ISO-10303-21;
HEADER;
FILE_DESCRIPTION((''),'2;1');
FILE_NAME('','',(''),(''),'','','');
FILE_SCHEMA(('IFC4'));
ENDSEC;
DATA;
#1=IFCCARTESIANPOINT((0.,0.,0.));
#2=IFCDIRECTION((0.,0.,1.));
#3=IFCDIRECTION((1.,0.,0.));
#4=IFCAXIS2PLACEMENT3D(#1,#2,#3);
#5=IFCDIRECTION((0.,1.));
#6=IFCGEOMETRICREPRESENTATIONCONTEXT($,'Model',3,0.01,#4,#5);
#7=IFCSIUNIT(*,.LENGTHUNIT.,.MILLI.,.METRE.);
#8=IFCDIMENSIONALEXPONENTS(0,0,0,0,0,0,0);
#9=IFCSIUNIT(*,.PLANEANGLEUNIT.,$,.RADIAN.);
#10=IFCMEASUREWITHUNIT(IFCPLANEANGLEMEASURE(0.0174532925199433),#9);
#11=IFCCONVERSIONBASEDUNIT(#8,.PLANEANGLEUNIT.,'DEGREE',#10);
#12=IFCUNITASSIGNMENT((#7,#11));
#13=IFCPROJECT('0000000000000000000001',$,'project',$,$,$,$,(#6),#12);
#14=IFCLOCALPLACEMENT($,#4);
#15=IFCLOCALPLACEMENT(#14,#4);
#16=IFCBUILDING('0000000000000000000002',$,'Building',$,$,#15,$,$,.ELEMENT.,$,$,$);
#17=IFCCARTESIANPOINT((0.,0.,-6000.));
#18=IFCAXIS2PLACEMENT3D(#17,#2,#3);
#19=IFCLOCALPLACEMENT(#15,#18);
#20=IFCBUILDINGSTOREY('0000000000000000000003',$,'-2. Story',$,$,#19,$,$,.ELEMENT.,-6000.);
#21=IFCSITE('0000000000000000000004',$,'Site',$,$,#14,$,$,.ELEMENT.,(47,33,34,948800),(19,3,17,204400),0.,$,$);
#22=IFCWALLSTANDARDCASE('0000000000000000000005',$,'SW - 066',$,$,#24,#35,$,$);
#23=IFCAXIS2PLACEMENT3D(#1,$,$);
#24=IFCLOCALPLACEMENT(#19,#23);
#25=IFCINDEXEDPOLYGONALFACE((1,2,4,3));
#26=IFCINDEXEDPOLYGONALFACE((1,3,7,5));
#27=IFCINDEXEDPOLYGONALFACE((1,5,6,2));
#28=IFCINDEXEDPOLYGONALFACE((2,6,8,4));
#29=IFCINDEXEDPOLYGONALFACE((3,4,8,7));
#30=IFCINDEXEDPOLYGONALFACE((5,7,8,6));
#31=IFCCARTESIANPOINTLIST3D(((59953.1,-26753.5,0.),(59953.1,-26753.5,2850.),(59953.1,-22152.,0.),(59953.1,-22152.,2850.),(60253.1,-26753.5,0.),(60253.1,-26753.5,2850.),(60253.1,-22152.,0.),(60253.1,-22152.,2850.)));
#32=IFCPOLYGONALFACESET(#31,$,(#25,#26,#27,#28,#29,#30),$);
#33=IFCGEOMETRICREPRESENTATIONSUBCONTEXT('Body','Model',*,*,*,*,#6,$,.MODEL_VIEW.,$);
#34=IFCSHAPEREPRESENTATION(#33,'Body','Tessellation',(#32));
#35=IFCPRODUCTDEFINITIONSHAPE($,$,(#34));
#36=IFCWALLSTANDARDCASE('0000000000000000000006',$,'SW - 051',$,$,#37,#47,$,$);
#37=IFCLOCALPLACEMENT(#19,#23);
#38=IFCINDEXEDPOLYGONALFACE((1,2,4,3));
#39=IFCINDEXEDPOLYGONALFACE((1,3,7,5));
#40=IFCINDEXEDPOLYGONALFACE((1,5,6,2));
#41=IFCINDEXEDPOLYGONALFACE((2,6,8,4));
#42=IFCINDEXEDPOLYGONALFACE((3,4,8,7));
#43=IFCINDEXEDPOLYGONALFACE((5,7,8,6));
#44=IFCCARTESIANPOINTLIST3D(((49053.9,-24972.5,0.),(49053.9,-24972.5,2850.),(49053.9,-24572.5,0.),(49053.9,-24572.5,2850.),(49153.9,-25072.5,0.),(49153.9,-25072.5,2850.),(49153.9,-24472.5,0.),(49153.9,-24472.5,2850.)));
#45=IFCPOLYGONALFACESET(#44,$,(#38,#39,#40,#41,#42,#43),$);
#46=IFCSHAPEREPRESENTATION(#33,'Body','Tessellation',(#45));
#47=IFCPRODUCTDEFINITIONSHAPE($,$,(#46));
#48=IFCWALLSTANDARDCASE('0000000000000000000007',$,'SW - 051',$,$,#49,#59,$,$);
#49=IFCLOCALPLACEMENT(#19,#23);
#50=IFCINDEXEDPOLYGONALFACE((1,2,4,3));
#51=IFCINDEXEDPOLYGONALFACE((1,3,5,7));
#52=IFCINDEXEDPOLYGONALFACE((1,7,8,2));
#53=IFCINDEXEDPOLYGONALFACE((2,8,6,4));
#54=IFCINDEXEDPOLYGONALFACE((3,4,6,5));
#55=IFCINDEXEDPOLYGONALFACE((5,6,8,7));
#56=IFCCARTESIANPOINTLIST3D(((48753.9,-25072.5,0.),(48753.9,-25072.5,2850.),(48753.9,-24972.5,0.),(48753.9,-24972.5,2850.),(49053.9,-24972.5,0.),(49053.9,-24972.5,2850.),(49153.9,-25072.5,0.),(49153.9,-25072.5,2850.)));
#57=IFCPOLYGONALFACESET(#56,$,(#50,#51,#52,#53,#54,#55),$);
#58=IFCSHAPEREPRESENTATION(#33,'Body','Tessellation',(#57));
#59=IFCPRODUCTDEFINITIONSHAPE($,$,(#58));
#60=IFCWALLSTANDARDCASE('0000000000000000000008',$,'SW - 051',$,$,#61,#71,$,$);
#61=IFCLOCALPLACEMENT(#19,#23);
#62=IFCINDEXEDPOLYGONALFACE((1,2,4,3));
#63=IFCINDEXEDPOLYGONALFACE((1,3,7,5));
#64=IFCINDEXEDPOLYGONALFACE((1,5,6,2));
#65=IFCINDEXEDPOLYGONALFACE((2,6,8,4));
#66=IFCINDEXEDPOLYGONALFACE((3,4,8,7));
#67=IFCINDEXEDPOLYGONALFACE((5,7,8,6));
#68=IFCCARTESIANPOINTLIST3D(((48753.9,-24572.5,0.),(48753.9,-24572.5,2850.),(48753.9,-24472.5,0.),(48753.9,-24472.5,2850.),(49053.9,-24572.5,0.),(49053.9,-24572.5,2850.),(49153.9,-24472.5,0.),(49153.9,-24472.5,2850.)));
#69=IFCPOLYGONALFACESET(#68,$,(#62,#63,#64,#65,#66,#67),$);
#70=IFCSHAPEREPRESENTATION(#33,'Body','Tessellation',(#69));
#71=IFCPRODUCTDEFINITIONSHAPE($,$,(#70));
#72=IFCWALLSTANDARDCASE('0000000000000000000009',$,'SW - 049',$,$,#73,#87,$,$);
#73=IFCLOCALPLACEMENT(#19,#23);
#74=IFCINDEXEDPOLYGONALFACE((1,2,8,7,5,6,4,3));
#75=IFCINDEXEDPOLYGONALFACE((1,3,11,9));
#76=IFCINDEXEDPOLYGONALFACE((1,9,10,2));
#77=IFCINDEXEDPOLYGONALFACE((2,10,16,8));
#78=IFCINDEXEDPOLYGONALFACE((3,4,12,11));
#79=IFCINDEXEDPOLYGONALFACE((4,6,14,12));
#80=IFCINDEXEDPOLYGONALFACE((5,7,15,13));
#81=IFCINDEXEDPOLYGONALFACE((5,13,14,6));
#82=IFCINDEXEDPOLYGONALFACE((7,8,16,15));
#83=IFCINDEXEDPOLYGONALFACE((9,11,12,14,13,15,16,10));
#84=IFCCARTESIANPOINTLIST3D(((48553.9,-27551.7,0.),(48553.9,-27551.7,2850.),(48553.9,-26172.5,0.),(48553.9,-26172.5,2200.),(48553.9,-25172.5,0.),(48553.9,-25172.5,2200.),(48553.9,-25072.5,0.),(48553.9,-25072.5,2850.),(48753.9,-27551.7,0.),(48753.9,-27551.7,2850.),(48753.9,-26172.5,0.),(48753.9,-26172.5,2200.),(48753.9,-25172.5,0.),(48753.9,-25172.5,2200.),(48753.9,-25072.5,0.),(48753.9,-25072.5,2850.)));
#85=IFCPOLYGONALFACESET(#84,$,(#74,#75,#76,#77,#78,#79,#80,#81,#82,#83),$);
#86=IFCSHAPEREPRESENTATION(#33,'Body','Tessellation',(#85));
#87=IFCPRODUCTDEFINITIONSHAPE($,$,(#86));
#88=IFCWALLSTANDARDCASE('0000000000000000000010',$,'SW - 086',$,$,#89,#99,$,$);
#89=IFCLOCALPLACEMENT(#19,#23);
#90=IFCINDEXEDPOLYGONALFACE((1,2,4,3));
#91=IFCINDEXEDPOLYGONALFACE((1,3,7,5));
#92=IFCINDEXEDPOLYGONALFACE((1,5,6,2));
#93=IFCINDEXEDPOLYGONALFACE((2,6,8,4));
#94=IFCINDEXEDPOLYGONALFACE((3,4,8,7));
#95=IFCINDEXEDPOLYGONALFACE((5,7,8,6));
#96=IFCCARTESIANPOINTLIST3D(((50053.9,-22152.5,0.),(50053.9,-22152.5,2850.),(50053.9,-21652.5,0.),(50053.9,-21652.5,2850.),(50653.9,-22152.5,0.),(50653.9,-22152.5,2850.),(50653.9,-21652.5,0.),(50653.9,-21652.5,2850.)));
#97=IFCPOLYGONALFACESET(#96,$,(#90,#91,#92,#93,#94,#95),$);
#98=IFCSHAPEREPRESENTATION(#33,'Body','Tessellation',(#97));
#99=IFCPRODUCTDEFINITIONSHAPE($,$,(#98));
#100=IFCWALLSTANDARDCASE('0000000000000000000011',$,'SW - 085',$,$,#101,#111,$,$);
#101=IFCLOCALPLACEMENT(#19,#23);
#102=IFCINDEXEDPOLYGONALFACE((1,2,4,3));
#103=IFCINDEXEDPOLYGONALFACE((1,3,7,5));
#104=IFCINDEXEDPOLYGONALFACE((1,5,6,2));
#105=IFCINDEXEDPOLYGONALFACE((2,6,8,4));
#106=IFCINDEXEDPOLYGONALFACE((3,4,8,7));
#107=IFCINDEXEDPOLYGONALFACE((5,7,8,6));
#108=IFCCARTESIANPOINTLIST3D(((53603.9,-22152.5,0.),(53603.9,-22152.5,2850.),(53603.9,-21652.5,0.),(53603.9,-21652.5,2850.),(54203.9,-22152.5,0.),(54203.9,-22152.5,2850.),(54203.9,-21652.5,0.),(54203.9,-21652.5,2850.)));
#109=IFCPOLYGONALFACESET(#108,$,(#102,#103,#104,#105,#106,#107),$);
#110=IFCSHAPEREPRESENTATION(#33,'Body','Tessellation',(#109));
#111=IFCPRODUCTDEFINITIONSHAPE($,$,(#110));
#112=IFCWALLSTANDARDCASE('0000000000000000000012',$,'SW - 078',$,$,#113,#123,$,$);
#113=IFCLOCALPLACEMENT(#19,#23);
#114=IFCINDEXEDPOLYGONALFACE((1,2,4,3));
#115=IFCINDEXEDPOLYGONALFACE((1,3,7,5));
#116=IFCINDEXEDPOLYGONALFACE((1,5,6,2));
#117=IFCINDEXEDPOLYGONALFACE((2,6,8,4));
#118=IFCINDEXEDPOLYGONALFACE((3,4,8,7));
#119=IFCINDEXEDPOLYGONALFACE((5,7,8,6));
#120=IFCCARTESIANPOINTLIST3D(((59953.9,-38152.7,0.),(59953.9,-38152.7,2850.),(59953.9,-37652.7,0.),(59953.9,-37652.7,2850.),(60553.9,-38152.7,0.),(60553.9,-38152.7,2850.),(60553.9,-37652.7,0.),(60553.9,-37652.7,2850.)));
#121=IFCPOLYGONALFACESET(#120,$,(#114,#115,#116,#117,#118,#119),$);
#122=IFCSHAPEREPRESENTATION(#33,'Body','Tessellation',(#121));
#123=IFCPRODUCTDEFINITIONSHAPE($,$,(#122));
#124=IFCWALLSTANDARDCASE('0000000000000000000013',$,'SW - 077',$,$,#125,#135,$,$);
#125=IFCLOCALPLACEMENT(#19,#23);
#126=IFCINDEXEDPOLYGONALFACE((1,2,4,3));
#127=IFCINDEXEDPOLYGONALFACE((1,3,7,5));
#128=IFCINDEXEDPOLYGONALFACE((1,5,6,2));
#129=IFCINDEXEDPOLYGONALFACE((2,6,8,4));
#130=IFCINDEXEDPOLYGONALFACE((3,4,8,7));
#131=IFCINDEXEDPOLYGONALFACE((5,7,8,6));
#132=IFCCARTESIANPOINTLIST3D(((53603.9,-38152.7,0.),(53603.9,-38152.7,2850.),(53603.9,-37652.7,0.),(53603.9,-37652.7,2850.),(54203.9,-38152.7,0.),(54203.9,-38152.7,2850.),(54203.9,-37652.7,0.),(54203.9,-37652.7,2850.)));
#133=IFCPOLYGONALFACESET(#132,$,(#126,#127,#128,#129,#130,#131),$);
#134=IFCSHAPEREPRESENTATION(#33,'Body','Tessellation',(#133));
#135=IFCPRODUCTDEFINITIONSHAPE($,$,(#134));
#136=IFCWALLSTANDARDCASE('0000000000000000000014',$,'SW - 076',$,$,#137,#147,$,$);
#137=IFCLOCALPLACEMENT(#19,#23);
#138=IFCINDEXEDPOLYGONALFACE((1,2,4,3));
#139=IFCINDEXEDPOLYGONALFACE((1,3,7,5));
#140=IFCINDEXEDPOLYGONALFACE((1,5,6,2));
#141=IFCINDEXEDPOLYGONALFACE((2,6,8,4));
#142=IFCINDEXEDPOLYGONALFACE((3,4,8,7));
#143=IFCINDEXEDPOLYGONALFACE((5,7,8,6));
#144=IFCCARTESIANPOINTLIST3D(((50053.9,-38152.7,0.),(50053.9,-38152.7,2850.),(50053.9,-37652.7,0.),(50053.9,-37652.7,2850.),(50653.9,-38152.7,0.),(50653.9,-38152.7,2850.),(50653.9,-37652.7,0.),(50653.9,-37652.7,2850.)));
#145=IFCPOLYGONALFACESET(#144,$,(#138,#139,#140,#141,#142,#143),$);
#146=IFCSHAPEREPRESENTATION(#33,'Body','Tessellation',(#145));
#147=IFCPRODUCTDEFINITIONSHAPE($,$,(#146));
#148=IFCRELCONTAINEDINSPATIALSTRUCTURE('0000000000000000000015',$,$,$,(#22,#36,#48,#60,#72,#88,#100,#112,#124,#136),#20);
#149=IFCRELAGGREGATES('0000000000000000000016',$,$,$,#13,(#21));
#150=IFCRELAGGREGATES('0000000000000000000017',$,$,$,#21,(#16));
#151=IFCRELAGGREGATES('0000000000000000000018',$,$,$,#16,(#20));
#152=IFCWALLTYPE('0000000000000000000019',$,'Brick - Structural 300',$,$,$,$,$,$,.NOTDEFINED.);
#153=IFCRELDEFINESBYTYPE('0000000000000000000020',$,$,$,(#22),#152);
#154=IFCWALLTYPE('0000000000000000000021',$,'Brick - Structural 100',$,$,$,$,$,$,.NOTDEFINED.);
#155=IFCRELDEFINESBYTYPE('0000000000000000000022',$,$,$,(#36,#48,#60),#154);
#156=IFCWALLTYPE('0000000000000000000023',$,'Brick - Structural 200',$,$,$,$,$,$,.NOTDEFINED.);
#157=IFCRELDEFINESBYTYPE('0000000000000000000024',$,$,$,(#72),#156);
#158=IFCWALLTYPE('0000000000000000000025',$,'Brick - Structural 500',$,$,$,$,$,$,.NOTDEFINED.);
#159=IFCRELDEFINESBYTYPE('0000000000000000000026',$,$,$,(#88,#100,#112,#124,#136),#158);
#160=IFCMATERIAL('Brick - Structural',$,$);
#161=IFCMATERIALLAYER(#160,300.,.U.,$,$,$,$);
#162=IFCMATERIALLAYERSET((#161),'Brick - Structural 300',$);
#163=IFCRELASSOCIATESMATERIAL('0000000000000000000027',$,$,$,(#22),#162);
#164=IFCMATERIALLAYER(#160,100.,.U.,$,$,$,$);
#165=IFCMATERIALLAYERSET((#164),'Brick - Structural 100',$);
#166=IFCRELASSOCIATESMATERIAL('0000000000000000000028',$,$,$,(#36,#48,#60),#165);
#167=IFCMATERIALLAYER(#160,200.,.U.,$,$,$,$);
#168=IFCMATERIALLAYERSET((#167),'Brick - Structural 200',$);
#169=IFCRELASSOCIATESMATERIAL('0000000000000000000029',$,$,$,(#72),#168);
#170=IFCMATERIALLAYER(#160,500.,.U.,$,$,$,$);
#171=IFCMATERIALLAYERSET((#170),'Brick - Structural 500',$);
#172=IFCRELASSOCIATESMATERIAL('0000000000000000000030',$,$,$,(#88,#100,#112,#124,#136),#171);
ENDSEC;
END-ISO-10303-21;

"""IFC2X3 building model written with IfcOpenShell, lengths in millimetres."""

from ifc_helpers import new_model, entity, si_unit, converted_unit, direction, frame, origin_with_axes, origin_2d_with_axis, place, context, subcontext, project, spatial, polyline, rectangle, outline, extrude, material, layer, layer_set, layer_usage, type_object, element, save


model = new_model("IFC2X3")

# Units and contexts
model_context = context("Model", 3, precision=0.01, world=origin_with_axes(), true_north=direction((0.0, 1.0)))
body_context = subcontext(model_context, "Body", "Model", "MODEL_VIEW")
ifc_project = project(units=[si_unit("LENGTHUNIT", "METRE", prefix="MILLI"), converted_unit("PLANEANGLEUNIT", "DEGREE", entity("IfcPlaneAngleMeasure", 0.0174532925199433), si_unit("PLANEANGLEUNIT", "RADIAN"), dimensions=[0, 0, 0, 0, 0, 0, 0])], contexts=[model_context])

# Site, building, storey
site_placement = place(None, origin_with_axes())
site = spatial("IfcSite", under=ifc_project, at=site_placement, Name="Site", CompositionType="ELEMENT", RefLatitude=(47, 33, 34, 948800), RefLongitude=(19, 3, 17, 204400), RefElevation=0.0)
building_placement = place(site_placement, origin_with_axes())
building = spatial("IfcBuilding", under=site, at=building_placement, Name="Building", CompositionType="ELEMENT")
storey_placement = place(building_placement, frame((0.0, 0.0, -6000.0), z_axis=(0.0, 0.0, 1.0), x_axis=(1.0, 0.0, 0.0)))
storey = spatial("IfcBuildingStorey", under=building, at=storey_placement, Name="-2. Story", CompositionType="ELEMENT", Elevation=-6000.0)

# Shared definitions
ifc_material_1 = material(Name="Brick - Structural")
ifc_layer_1 = layer(ifc_material_1, 300.0, ventilated="UNKNOWN")
ifc_layer_set_1 = layer_set([ifc_layer_1], Name="Brick - Structural 300")
wall_type_1 = type_object("IfcWallType", Name="Brick - Structural 300", PredefinedType="NOTDEFINED")

# Walls
ifc_layer_usage_1 = layer_usage(ifc_layer_set_1, "AXIS2", "POSITIVE", 0.0)
wall_1_placement = place(storey_placement, frame((59953.1, -22152.0, 0.0), z_axis=(0.0, 0.0, 1.0), x_axis=(0.0, -1.0, 0.0)))
element("IfcWallStandardCase", 1, at=wall_1_placement, inside=storey, type_object=wall_type_1, material=ifc_layer_usage_1, Name="SW - 066", context=body_context, shape_type="SweptSolid", body=[
    extrude(outline(polyline([(0.0, 0.0), (4601.5, 0.0), (4601.5, 300.0), (0.0, 300.0), (0.0, 0.0)])), origin_with_axes(), (0.0, 0.0, 1.0), 2850.0),
])
ifc_layer_2 = layer(ifc_material_1, 100.0, ventilated="UNKNOWN")
ifc_layer_set_2 = layer_set([ifc_layer_2], Name="Brick - Structural 100")
ifc_layer_usage_2 = layer_usage(ifc_layer_set_2, "AXIS2", "NEGATIVE", 0.0)
wall_type_2 = type_object("IfcWallType", Name="Brick - Structural 100", PredefinedType="NOTDEFINED")
wall_2_placement = place(storey_placement, frame((49053.9, -25072.5, 0.0), z_axis=(0.0, 0.0, 1.0), x_axis=(0.0, 1.0, 0.0)))
element("IfcWallStandardCase", 2, at=wall_2_placement, inside=storey, type_object=wall_type_2, material=ifc_layer_usage_2, Name="SW - 051", context=body_context, shape_type="SweptSolid", body=[
    extrude(outline(polyline([(0.0, -100.0), (600.0, -100.0), (500.0, 0.0), (100.0, 0.0), (0.0, -100.0)])), origin_with_axes(), (0.0, 0.0, 1.0), 2850.0),
])
ifc_layer_usage_3 = layer_usage(ifc_layer_set_2, "AXIS2", "NEGATIVE", 0.0)
wall_3_placement = place(storey_placement, frame((49053.9, -25072.5, 0.0), z_axis=(0.0, 0.0, 1.0), x_axis=(-1.0, 0.0, 0.0)))
element("IfcWallStandardCase", 3, at=wall_3_placement, inside=storey, type_object=wall_type_2, material=ifc_layer_usage_3, Name="SW - 051", context=body_context, shape_type="SweptSolid", body=[
    extrude(outline(polyline([(0.0, -100.0), (300.0, -100.0), (300.0, 0.0), (-100.0, 0.0), (0.0, -100.0)])), origin_with_axes(), (0.0, 0.0, 1.0), 2850.0),
])
ifc_layer_usage_4 = layer_usage(ifc_layer_set_2, "AXIS2", "NEGATIVE", 0.0)
wall_4_placement = place(storey_placement, frame((49053.9, -24572.5, 0.0), z_axis=(0.0, 0.0, 1.0), x_axis=(-1.0, 0.0, 0.0)))
element("IfcWallStandardCase", 4, at=wall_4_placement, inside=storey, type_object=wall_type_2, material=ifc_layer_usage_4, Name="SW - 051", context=body_context, shape_type="SweptSolid", body=[
    extrude(outline(polyline([(-100.0, -100.0), (300.0, -100.0), (300.0, 0.0), (0.0, 0.0), (-100.0, -100.0)])), origin_with_axes(), (0.0, 0.0, 1.0), 2850.0),
])

# Wall, opening
ifc_layer_3 = layer(ifc_material_1, 200.0, ventilated="UNKNOWN")
ifc_layer_set_3 = layer_set([ifc_layer_3], Name="Brick - Structural 200")
ifc_layer_usage_5 = layer_usage(ifc_layer_set_3, "AXIS2", "POSITIVE", 0.0)
wall_type_3 = type_object("IfcWallType", Name="Brick - Structural 200", PredefinedType="NOTDEFINED")
wall_5_placement = place(storey_placement, frame((48553.9, -25072.5, 0.0), z_axis=(0.0, 0.0, 1.0), x_axis=(0.0, -1.0, 0.0)))
wall_5 = element("IfcWallStandardCase", 5, at=wall_5_placement, inside=storey, type_object=wall_type_3, material=ifc_layer_usage_5, Name="SW - 049", context=body_context, shape_type="SweptSolid", body=[
    extrude(outline(polyline([(0.0, 0.0), (2479.2, 0.0), (2479.2, 200.0), (0.0, 200.0), (0.0, 0.0)])), origin_with_axes(), (0.0, 0.0, 1.0), 2850.0),
])
opening_1_placement = place(wall_5_placement, frame((600.0, 0.0, 0.0), z_axis=(0.0, 0.0, 1.0), x_axis=(1.0, 0.0, 0.0)))
element("IfcOpeningElement", 6, at=opening_1_placement, cuts=wall_5, context=body_context, shape_type="SweptSolid", body=[
    extrude(rectangle(XDim=1000.0, YDim=2200.0, at=origin_2d_with_axis()), frame((0.0, 200.0, 1100.0), z_axis=(0.0, -1.0, 0.0), x_axis=(1.0, 0.0, 0.0)), (0.0, 0.0, -1.0), 200.0),
    extrude(rectangle(XDim=1000.0, YDim=2200.0, at=origin_2d_with_axis()), frame((0.0, 200.0, 1100.0), z_axis=(0.0, 1.0, 0.0), x_axis=(1.0, 0.0, 0.0)), (0.0, 0.0, -1.0), 200.0),
])

# Walls
ifc_layer_4 = layer(ifc_material_1, 500.0, ventilated="UNKNOWN")
ifc_layer_set_4 = layer_set([ifc_layer_4], Name="Brick - Structural 500")
ifc_layer_usage_6 = layer_usage(ifc_layer_set_4, "AXIS2", "NEGATIVE", 0.0)
wall_type_4 = type_object("IfcWallType", Name="Brick - Structural 500", PredefinedType="NOTDEFINED")
wall_6_placement = place(storey_placement, frame((50053.9, -21652.5, 0.0), z_axis=(0.0, 0.0, 1.0), x_axis=(1.0, 0.0, 0.0)))
element("IfcWallStandardCase", 7, at=wall_6_placement, inside=storey, type_object=wall_type_4, material=ifc_layer_usage_6, Name="SW - 086", context=body_context, shape_type="SweptSolid", body=[
    extrude(outline(polyline([(0.0, -500.0), (600.0, -500.0), (600.0, 0.0), (0.0, 0.0), (0.0, -500.0)])), origin_with_axes(), (0.0, 0.0, 1.0), 2850.0),
])
ifc_layer_usage_7 = layer_usage(ifc_layer_set_4, "AXIS2", "POSITIVE", 0.0)
wall_7_placement = place(storey_placement, frame((54203.9, -21652.5, 0.0), z_axis=(0.0, 0.0, 1.0), x_axis=(-1.0, 0.0, 0.0)))
element("IfcWallStandardCase", 8, at=wall_7_placement, inside=storey, type_object=wall_type_4, material=ifc_layer_usage_7, Name="SW - 085", context=body_context, shape_type="SweptSolid", body=[
    extrude(outline(polyline([(0.0, 0.0), (600.0, 0.0), (600.0, 500.0), (0.0, 500.0), (0.0, 0.0)])), origin_with_axes(), (0.0, 0.0, 1.0), 2850.0),
])
ifc_layer_usage_8 = layer_usage(ifc_layer_set_4, "AXIS2", "POSITIVE", 0.0)
wall_8_placement = place(storey_placement, frame((59953.9, -38152.7, 0.0), z_axis=(0.0, 0.0, 1.0), x_axis=(1.0, 0.0, 0.0)))
element("IfcWallStandardCase", 9, at=wall_8_placement, inside=storey, type_object=wall_type_4, material=ifc_layer_usage_8, Name="SW - 078", context=body_context, shape_type="SweptSolid", body=[
    extrude(outline(polyline([(0.0, 0.0), (600.0, 0.0), (600.0, 500.0), (0.0, 500.0), (0.0, 0.0)])), origin_with_axes(), (0.0, 0.0, 1.0), 2850.0),
])
ifc_layer_usage_9 = layer_usage(ifc_layer_set_4, "AXIS2", "POSITIVE", 0.0)
wall_9_placement = place(storey_placement, frame((53603.9, -38152.7, 0.0), z_axis=(0.0, 0.0, 1.0), x_axis=(1.0, 0.0, 0.0)))
element("IfcWallStandardCase", 10, at=wall_9_placement, inside=storey, type_object=wall_type_4, material=ifc_layer_usage_9, Name="SW - 077", context=body_context, shape_type="SweptSolid", body=[
    extrude(outline(polyline([(0.0, 0.0), (600.0, 0.0), (600.0, 500.0), (0.0, 500.0), (0.0, 0.0)])), origin_with_axes(), (0.0, 0.0, 1.0), 2850.0),
])
ifc_layer_usage_10 = layer_usage(ifc_layer_set_4, "AXIS2", "POSITIVE", 0.0)
wall_10_placement = place(storey_placement, frame((50053.9, -38152.7, 0.0), z_axis=(0.0, 0.0, 1.0), x_axis=(1.0, 0.0, 0.0)))
element("IfcWallStandardCase", 11, at=wall_10_placement, inside=storey, type_object=wall_type_4, material=ifc_layer_usage_10, Name="SW - 076", context=body_context, shape_type="SweptSolid", body=[
    extrude(outline(polyline([(0.0, 0.0), (600.0, 0.0), (600.0, 500.0), (0.0, 500.0), (0.0, 0.0)])), origin_with_axes(), (0.0, 0.0, 1.0), 2850.0),
])

save(model, "model.ifc")
